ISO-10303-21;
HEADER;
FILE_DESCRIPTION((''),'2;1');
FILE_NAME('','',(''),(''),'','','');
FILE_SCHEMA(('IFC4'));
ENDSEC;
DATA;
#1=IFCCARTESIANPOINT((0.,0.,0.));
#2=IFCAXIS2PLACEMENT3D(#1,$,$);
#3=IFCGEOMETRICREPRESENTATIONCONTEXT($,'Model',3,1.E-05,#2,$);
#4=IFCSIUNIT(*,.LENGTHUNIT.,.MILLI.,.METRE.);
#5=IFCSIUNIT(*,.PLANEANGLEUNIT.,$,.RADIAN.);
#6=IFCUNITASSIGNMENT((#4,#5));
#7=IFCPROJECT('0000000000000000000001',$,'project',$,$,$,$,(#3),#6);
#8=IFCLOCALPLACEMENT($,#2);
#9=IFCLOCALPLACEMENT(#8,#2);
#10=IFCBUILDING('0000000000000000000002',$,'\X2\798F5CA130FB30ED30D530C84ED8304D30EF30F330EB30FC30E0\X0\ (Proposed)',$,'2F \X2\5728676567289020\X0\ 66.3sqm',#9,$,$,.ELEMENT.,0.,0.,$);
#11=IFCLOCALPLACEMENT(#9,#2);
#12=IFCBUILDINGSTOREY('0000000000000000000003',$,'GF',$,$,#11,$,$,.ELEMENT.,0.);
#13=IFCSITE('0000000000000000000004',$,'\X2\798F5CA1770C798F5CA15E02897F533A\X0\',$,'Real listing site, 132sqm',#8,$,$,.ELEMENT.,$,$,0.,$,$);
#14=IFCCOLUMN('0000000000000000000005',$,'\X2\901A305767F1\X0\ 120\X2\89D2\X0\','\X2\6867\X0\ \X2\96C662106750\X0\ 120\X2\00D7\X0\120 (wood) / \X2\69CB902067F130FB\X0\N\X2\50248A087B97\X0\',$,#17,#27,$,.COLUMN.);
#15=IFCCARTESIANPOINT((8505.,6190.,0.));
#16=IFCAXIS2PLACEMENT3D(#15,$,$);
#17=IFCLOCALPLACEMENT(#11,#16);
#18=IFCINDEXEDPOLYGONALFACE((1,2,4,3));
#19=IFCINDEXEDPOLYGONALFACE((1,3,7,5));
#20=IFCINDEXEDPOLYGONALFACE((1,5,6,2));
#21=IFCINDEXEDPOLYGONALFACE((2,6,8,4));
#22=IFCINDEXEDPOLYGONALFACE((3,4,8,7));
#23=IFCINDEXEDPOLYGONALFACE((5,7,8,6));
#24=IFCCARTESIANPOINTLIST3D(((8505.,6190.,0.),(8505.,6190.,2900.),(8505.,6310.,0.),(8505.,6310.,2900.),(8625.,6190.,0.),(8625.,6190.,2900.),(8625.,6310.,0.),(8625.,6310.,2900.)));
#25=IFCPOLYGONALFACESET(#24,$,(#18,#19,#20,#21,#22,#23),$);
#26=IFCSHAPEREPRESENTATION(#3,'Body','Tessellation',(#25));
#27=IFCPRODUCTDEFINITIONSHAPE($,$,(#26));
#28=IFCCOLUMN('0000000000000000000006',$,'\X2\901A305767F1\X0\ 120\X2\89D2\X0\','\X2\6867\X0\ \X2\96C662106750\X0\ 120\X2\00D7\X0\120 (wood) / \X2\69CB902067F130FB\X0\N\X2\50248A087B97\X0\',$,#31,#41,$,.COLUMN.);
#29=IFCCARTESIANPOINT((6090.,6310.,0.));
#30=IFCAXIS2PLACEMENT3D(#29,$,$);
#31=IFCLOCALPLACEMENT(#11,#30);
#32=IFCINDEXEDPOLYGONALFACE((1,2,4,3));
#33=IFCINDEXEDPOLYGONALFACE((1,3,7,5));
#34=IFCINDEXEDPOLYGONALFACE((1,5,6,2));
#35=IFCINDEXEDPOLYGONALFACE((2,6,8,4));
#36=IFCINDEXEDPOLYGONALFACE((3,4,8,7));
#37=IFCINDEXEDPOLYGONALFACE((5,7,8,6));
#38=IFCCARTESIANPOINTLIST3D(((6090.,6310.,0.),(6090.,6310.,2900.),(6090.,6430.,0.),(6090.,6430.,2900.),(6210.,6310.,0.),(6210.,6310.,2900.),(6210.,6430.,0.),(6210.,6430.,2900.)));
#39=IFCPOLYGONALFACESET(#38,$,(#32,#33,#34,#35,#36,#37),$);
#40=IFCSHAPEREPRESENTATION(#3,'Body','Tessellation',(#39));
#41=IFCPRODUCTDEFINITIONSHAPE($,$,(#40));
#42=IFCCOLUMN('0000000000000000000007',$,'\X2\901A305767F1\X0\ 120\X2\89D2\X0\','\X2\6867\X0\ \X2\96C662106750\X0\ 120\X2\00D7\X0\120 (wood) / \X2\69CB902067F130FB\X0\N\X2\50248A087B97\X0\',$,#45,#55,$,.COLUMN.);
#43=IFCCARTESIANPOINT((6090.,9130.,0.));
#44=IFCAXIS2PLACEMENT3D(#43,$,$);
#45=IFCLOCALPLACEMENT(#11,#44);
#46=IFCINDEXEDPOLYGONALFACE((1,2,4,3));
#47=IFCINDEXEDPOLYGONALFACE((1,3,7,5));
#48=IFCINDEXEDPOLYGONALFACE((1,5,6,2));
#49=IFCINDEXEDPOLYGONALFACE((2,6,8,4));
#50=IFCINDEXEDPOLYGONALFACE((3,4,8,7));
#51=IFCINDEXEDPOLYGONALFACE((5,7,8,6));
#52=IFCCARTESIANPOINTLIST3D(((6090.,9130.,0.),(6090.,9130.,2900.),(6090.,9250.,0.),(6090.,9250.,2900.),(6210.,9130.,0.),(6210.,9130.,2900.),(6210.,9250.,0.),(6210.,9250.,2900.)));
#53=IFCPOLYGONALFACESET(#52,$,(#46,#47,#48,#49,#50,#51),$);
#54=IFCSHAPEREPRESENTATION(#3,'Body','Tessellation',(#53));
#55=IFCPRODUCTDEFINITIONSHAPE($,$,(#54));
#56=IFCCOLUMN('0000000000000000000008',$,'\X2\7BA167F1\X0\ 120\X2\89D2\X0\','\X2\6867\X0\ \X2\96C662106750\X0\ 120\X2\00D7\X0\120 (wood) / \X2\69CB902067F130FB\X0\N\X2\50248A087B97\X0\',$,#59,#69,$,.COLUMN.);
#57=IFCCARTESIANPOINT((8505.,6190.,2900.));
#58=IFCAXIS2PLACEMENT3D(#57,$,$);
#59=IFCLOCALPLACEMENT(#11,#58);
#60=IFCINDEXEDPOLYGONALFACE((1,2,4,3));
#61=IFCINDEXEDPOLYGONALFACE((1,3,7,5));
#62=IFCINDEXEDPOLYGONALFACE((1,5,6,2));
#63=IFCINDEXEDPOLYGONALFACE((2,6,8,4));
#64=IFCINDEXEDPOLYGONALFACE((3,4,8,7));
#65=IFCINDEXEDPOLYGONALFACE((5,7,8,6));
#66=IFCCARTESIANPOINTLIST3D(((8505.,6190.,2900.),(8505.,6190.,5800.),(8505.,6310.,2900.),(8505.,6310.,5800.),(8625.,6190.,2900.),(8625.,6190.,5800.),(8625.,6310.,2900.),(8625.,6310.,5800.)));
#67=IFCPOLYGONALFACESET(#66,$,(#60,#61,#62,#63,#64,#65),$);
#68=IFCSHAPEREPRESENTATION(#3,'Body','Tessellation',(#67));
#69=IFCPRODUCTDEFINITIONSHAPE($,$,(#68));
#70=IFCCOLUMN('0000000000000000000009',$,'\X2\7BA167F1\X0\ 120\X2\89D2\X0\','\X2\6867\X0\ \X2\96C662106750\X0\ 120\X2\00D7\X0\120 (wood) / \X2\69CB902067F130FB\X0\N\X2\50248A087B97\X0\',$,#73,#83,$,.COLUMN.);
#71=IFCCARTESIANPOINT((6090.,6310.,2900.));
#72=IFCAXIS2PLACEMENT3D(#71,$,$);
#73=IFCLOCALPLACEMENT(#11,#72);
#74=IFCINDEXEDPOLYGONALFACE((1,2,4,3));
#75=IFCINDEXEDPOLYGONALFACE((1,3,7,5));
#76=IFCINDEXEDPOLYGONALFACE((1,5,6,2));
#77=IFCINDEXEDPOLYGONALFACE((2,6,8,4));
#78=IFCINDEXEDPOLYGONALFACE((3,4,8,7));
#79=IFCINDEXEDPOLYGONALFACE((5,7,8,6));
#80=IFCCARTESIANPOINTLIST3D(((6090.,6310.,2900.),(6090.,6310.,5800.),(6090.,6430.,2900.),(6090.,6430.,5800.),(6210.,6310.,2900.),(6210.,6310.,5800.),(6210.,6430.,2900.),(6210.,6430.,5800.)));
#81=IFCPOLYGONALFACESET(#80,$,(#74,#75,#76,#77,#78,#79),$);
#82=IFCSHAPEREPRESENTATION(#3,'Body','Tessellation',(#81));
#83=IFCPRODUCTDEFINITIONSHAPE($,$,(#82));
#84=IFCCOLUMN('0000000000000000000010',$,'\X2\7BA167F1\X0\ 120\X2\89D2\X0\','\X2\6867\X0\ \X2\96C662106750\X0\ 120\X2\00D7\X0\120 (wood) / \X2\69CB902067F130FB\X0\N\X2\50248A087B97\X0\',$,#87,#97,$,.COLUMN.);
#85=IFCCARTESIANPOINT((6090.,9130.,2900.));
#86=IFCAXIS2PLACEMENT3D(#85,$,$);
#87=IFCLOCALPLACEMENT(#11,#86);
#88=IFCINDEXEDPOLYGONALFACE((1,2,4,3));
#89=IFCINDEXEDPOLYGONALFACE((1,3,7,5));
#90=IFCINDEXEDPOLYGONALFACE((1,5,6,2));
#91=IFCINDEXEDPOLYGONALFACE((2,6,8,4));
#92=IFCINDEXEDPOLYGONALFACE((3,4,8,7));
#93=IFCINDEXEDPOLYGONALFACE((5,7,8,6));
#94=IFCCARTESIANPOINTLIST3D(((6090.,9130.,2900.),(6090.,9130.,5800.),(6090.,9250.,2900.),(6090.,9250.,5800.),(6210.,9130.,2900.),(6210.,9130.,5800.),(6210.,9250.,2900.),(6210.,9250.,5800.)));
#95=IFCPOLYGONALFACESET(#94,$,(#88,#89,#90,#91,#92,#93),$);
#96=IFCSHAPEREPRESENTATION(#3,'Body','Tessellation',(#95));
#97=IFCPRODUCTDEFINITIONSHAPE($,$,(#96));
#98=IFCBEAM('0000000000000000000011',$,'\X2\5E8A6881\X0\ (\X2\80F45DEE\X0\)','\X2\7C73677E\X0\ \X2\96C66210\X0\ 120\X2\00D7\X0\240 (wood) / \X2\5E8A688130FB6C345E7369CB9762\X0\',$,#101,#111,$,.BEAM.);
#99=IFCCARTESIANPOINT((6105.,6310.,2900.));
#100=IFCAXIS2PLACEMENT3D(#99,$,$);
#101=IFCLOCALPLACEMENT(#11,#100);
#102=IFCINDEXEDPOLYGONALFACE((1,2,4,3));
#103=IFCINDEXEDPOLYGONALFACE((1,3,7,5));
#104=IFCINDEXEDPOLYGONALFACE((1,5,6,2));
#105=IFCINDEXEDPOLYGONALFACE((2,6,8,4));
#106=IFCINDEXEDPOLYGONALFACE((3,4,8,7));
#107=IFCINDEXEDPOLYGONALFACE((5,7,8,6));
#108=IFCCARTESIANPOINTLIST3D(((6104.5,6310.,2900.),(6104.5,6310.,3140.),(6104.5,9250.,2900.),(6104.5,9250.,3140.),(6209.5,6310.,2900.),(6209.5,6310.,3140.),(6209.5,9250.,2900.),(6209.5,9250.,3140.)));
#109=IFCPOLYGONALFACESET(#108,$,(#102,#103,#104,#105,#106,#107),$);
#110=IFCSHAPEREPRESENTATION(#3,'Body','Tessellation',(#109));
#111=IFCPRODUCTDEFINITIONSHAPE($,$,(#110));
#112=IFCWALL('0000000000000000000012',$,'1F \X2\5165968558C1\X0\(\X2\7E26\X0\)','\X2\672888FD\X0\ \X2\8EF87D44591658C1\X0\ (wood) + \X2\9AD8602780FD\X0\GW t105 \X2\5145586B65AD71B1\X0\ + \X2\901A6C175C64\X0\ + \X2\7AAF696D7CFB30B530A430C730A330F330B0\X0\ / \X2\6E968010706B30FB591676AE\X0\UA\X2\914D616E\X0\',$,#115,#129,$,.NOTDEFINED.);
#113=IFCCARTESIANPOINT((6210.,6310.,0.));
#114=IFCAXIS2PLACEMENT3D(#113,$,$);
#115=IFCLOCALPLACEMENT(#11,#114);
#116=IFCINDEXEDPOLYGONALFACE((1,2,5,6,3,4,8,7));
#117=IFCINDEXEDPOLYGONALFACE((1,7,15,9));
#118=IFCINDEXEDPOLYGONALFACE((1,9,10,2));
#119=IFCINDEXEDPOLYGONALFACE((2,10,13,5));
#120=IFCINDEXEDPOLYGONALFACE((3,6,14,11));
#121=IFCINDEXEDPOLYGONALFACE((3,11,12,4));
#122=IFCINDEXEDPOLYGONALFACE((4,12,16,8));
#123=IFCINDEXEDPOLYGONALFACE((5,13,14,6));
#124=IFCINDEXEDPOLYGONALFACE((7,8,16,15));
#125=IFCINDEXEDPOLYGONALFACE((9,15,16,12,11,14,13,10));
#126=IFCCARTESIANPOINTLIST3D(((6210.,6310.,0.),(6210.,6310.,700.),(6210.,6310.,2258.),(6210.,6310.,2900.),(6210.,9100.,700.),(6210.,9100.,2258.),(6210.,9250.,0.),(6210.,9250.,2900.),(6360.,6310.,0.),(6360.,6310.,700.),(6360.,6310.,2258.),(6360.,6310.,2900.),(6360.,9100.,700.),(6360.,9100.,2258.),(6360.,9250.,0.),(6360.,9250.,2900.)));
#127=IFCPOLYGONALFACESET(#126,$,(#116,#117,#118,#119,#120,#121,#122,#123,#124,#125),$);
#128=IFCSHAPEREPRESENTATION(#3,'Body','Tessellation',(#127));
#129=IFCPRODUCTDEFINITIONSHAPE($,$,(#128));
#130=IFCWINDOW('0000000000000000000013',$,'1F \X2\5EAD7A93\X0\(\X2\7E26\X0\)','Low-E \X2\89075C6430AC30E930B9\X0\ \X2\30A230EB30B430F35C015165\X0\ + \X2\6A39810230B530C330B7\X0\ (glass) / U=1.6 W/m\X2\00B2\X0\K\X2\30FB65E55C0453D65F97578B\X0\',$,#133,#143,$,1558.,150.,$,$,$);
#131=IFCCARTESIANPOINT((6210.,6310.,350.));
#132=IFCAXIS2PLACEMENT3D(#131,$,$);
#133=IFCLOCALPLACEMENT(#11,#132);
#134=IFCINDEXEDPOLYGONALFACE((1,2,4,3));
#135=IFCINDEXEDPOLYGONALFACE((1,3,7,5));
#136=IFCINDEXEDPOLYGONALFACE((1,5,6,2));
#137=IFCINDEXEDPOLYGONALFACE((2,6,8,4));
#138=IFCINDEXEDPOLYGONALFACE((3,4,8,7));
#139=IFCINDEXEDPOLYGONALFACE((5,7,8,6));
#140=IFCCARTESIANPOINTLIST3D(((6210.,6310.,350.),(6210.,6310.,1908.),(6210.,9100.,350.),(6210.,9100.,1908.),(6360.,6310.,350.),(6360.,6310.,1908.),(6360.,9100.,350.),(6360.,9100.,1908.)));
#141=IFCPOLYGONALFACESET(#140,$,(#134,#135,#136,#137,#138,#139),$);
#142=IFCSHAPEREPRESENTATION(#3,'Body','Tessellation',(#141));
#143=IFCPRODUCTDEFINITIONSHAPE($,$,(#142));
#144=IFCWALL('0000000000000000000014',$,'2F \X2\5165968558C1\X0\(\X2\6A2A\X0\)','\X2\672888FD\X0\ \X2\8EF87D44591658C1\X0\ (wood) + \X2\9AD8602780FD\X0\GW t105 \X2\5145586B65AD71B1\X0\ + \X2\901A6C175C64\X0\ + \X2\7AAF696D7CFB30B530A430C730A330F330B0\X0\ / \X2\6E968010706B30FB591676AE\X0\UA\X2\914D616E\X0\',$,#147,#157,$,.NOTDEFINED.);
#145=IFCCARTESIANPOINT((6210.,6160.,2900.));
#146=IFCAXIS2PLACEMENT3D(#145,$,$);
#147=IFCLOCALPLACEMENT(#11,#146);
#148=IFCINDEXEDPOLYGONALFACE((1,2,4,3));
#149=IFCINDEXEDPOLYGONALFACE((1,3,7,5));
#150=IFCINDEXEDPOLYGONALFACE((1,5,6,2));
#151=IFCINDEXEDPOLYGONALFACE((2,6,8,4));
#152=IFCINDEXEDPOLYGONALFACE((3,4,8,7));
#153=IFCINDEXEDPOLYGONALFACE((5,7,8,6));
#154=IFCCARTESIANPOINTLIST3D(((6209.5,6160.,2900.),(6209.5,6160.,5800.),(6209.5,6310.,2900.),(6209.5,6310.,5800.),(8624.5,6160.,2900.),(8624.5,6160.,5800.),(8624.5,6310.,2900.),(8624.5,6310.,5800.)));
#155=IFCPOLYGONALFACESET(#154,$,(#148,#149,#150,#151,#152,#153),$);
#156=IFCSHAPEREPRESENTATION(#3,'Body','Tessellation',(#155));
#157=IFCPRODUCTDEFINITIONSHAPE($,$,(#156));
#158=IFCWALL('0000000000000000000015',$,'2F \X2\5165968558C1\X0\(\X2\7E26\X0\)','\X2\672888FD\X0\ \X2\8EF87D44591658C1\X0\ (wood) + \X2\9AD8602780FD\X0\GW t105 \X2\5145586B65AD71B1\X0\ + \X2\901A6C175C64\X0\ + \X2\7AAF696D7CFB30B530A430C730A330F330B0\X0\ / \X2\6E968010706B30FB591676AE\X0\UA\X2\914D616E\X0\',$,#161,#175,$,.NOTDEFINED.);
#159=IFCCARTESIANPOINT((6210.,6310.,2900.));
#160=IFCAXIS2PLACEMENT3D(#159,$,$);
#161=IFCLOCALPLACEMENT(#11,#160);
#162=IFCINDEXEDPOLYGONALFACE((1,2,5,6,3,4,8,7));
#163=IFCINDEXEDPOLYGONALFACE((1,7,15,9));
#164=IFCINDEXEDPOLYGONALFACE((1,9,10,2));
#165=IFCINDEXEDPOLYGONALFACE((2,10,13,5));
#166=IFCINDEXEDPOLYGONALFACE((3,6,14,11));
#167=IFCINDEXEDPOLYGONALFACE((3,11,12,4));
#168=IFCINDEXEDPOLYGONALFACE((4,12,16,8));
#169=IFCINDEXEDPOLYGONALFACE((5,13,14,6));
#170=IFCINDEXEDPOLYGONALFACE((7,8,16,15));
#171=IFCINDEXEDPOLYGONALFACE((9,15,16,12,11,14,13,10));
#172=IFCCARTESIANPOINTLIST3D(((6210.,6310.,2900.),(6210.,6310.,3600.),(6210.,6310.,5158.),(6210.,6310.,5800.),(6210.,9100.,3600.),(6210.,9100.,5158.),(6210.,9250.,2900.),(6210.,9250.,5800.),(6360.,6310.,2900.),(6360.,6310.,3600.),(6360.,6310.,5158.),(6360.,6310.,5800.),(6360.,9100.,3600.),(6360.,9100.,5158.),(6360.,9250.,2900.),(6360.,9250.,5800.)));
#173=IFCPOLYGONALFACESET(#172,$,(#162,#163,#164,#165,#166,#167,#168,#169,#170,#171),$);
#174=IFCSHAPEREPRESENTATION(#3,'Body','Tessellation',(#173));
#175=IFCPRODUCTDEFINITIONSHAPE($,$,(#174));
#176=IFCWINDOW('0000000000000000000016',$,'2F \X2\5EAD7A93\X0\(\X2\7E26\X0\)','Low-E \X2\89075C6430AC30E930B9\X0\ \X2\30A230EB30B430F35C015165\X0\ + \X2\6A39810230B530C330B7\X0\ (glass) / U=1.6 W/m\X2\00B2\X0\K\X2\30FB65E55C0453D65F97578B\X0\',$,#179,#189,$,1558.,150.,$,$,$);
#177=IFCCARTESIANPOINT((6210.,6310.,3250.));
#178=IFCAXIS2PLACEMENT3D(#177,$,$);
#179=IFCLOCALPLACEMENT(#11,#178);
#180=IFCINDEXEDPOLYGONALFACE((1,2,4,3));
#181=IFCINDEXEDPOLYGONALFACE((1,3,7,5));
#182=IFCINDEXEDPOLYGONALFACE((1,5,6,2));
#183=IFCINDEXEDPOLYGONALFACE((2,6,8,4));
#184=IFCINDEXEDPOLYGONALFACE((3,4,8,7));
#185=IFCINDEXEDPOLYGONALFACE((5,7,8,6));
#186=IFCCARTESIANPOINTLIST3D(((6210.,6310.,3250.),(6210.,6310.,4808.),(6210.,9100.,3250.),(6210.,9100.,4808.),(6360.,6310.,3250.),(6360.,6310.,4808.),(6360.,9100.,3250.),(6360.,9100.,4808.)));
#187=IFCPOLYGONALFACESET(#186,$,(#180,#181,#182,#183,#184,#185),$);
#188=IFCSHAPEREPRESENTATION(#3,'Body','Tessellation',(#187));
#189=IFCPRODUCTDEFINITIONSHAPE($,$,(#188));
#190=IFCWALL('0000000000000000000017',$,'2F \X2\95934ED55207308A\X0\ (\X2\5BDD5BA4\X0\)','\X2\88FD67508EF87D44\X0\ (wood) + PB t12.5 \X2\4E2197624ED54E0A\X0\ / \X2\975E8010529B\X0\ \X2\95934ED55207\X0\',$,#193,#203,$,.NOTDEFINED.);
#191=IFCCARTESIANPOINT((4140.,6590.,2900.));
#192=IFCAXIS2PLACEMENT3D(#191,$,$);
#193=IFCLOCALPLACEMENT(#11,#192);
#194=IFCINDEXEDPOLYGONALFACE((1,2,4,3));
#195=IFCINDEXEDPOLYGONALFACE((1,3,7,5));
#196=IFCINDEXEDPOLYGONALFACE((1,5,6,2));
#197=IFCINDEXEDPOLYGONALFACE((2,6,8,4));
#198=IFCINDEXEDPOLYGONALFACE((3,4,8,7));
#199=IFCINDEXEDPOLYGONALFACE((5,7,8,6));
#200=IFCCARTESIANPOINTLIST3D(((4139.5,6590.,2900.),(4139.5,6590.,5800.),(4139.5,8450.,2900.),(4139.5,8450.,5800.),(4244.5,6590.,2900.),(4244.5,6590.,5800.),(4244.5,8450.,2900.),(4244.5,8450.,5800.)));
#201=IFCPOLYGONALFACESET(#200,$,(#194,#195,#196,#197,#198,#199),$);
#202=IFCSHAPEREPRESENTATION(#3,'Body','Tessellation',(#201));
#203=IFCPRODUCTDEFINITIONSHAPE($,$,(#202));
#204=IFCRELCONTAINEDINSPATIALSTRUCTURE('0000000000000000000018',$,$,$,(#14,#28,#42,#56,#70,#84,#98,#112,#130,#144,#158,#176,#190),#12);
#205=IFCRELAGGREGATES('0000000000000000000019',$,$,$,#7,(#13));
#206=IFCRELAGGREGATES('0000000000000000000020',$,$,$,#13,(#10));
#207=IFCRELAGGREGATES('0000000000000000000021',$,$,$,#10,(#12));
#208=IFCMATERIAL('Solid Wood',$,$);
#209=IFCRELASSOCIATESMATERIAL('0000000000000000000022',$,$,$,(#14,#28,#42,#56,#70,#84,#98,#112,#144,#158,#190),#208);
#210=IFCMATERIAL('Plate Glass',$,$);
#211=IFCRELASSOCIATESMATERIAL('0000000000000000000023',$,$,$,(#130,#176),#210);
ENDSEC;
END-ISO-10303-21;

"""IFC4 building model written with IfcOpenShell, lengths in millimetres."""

from ifc_helpers import new_model, si_unit, frame, frame_2d, origin, place, context, project, spatial, rectangle, extrude, material, element, fill, save


model = new_model("IFC4")

# Units and contexts
model_context = context("Model", 3, precision=1e-05, world=origin())
ifc_project = project(units=[si_unit("LENGTHUNIT", "METRE", prefix="MILLI"), si_unit("PLANEANGLEUNIT", "RADIAN")], contexts=[model_context])

# Site, building, storey
site_placement = place(None, origin())
site = spatial("IfcSite", under=ifc_project, at=site_placement, Name="福岡県福岡市西区", ObjectType="Real listing site, 132sqm", CompositionType="ELEMENT", RefElevation=0.0)
building_placement = place(site_placement, origin())
building = spatial("IfcBuilding", under=site, at=building_placement, Name="福岡・ロフト付きワンルーム (Proposed)", ObjectType="2F 在来木造 66.3sqm", CompositionType="ELEMENT", ElevationOfRefHeight=0.0, ElevationOfTerrain=0.0)
storey_placement = place(building_placement, origin())
storey = spatial("IfcBuildingStorey", under=building, at=storey_placement, Name="GF", CompositionType="ELEMENT", Elevation=0.0)

# Columns
ifc_material_1 = material(Name="Solid Wood")
column_1_placement = place(storey_placement, frame((8505.0, 6190.0, 0.0)))
element("IfcColumn", 1, at=column_1_placement, inside=storey, material=ifc_material_1, Name="通し柱 120角", Description="桧 集成材 120×120 (wood) / 構造柱・N値計算", PredefinedType="COLUMN", context=model_context, shape_type="SweptSolid", body=[
    extrude(rectangle(XDim=120.0, YDim=120.0, at=frame_2d((60.0, 60.0))), frame((8505.0, 6190.0, 0.0)), (0.0, 0.0, 1.0), 2900.0),
])
column_2_placement = place(storey_placement, frame((6090.0, 6310.0, 0.0)))
element("IfcColumn", 2, at=column_2_placement, inside=storey, material=ifc_material_1, Name="通し柱 120角", Description="桧 集成材 120×120 (wood) / 構造柱・N値計算", PredefinedType="COLUMN", context=model_context, shape_type="SweptSolid", body=[
    extrude(rectangle(XDim=120.0, YDim=120.0, at=frame_2d((60.0, 60.0))), frame((6090.0, 6310.0, 0.0)), (0.0, 0.0, 1.0), 2900.0),
])
column_3_placement = place(storey_placement, frame((6090.0, 9130.0, 0.0)))
element("IfcColumn", 3, at=column_3_placement, inside=storey, material=ifc_material_1, Name="通し柱 120角", Description="桧 集成材 120×120 (wood) / 構造柱・N値計算", PredefinedType="COLUMN", context=model_context, shape_type="SweptSolid", body=[
    extrude(rectangle(XDim=120.0, YDim=120.0, at=frame_2d((60.0, 60.0))), frame((6090.0, 9130.0, 0.0)), (0.0, 0.0, 1.0), 2900.0),
])
column_4_placement = place(storey_placement, frame((8505.0, 6190.0, 2900.0)))
element("IfcColumn", 4, at=column_4_placement, inside=storey, material=ifc_material_1, Name="管柱 120角", Description="桧 集成材 120×120 (wood) / 構造柱・N値計算", PredefinedType="COLUMN", context=model_context, shape_type="SweptSolid", body=[
    extrude(rectangle(XDim=120.0, YDim=120.0, at=frame_2d((60.0, 60.0))), frame((8505.0, 6190.0, 2900.0)), (0.0, 0.0, 1.0), 2900.0),
])
column_5_placement = place(storey_placement, frame((6090.0, 6310.0, 2900.0)))
element("IfcColumn", 5, at=column_5_placement, inside=storey, material=ifc_material_1, Name="管柱 120角", Description="桧 集成材 120×120 (wood) / 構造柱・N値計算", PredefinedType="COLUMN", context=model_context, shape_type="SweptSolid", body=[
    extrude(rectangle(XDim=120.0, YDim=120.0, at=frame_2d((60.0, 60.0))), frame((6090.0, 6310.0, 2900.0)), (0.0, 0.0, 1.0), 2900.0),
])
column_6_placement = place(storey_placement, frame((6090.0, 9130.0, 2900.0)))
element("IfcColumn", 6, at=column_6_placement, inside=storey, material=ifc_material_1, Name="管柱 120角", Description="桧 集成材 120×120 (wood) / 構造柱・N値計算", PredefinedType="COLUMN", context=model_context, shape_type="SweptSolid", body=[
    extrude(rectangle(XDim=120.0, YDim=120.0, at=frame_2d((60.0, 60.0))), frame((6090.0, 9130.0, 2900.0)), (0.0, 0.0, 1.0), 2900.0),
])

# Beam
beam_1_placement = place(storey_placement, frame((6105.0, 6310.0, 2900.0)))
element("IfcBeam", 7, at=beam_1_placement, inside=storey, material=ifc_material_1, Name="床梁 (胴差)", Description="米松 集成 120×240 (wood) / 床梁・水平構面", PredefinedType="BEAM", context=model_context, shape_type="SweptSolid", body=[
    extrude(rectangle(XDim=105.0, YDim=2940.0, at=frame_2d((52.0, 1470.0))), frame((6105.0, 6310.0, 2900.0)), (0.0, 0.0, 1.0), 240.0),
])

# Wall, opening, window
wall_1_placement = place(storey_placement, frame((6210.0, 6310.0, 0.0)))
wall_1 = element("IfcWall", 8, at=wall_1_placement, inside=storey, material=ifc_material_1, Name="1F 入隅壁(縦)", Description="木製 軸組外壁 (wood) + 高性能GW t105 充填断熱 + 通気層 + 窯業系サイディング / 準耐火・外皮UA配慮", PredefinedType="NOTDEFINED", context=model_context, shape_type="SweptSolid", body=[
    extrude(rectangle(XDim=150.0, YDim=2940.0, at=frame_2d((75.0, 1470.0))), frame((6210.0, 6310.0, 0.0)), (0.0, 0.0, 1.0), 2900.0),
])
opening_1_placement = place(storey_placement, frame((6210.0, 6310.0, 350.0)))
opening_1 = element("IfcOpeningElement", 9, at=opening_1_placement, cuts=wall_1, PredefinedType="NOTDEFINED", context=model_context, shape_type="SweptSolid", body=[
    extrude(rectangle(XDim=150.0, YDim=2790.0, at=frame_2d((75.0, 1395.0))), frame((6210.0, 6310.0, 350.0)), (0.0, 0.0, 1.0), 1558.0),
])
ifc_material_2 = material(Name="Plate Glass")
window_1_placement = place(storey_placement, frame((6210.0, 6310.0, 350.0)))
window_1 = element("IfcWindow", 10, at=window_1_placement, inside=storey, material=ifc_material_2, Name="1F 庭窓(縦)", Description="Low-E 複層ガラス アルゴン封入 + 樹脂サッシ (glass) / U=1.6 W/m²K・日射取得型", OverallHeight=1558.0, OverallWidth=150.0, context=model_context, shape_type="SweptSolid", body=[
    extrude(rectangle(XDim=150.0, YDim=2790.0, at=frame_2d((75.0, 1395.0))), frame((6210.0, 6310.0, 350.0)), (0.0, 0.0, 1.0), 1558.0),
])
fill(opening_1, window_1)

# Wall
wall_2_placement = place(storey_placement, frame((6210.0, 6160.0, 2900.0)))
element("IfcWall", 11, at=wall_2_placement, inside=storey, material=ifc_material_1, Name="2F 入隅壁(横)", Description="木製 軸組外壁 (wood) + 高性能GW t105 充填断熱 + 通気層 + 窯業系サイディング / 準耐火・外皮UA配慮", PredefinedType="NOTDEFINED", context=model_context, shape_type="SweptSolid", body=[
    extrude(rectangle(XDim=2415.0, YDim=150.0, at=frame_2d((1207.0, 75.0))), frame((6210.0, 6160.0, 2900.0)), (0.0, 0.0, 1.0), 2900.0),
])

# Wall, opening, window
wall_3_placement = place(storey_placement, frame((6210.0, 6310.0, 2900.0)))
wall_3 = element("IfcWall", 12, at=wall_3_placement, inside=storey, material=ifc_material_1, Name="2F 入隅壁(縦)", Description="木製 軸組外壁 (wood) + 高性能GW t105 充填断熱 + 通気層 + 窯業系サイディング / 準耐火・外皮UA配慮", PredefinedType="NOTDEFINED", context=model_context, shape_type="SweptSolid", body=[
    extrude(rectangle(XDim=150.0, YDim=2940.0, at=frame_2d((75.0, 1470.0))), frame((6210.0, 6310.0, 2900.0)), (0.0, 0.0, 1.0), 2900.0),
])
opening_2_placement = place(storey_placement, frame((6210.0, 6310.0, 3250.0)))
opening_2 = element("IfcOpeningElement", 13, at=opening_2_placement, cuts=wall_3, PredefinedType="NOTDEFINED", context=model_context, shape_type="SweptSolid", body=[
    extrude(rectangle(XDim=150.0, YDim=2790.0, at=frame_2d((75.0, 1395.0))), frame((6210.0, 6310.0, 3250.0)), (0.0, 0.0, 1.0), 1558.0),
])
window_2_placement = place(storey_placement, frame((6210.0, 6310.0, 3250.0)))
window_2 = element("IfcWindow", 14, at=window_2_placement, inside=storey, material=ifc_material_2, Name="2F 庭窓(縦)", Description="Low-E 複層ガラス アルゴン封入 + 樹脂サッシ (glass) / U=1.6 W/m²K・日射取得型", OverallHeight=1558.0, OverallWidth=150.0, context=model_context, shape_type="SweptSolid", body=[
    extrude(rectangle(XDim=150.0, YDim=2790.0, at=frame_2d((75.0, 1395.0))), frame((6210.0, 6310.0, 3250.0)), (0.0, 0.0, 1.0), 1558.0),
])
fill(opening_2, window_2)

# Wall
wall_4_placement = place(storey_placement, frame((4140.0, 6590.0, 2900.0)))
element("IfcWall", 15, at=wall_4_placement, inside=storey, material=ifc_material_1, Name="2F 間仕切り (寝室)", Description="製材軸組 (wood) + PB t12.5 両面仕上 / 非耐力 間仕切", PredefinedType="NOTDEFINED", context=model_context, shape_type="SweptSolid", body=[
    extrude(rectangle(XDim=105.0, YDim=1860.0, at=frame_2d((52.0, 930.0))), frame((4140.0, 6590.0, 2900.0)), (0.0, 0.0, 1.0), 2900.0),
])

save(model, "model.ifc")
